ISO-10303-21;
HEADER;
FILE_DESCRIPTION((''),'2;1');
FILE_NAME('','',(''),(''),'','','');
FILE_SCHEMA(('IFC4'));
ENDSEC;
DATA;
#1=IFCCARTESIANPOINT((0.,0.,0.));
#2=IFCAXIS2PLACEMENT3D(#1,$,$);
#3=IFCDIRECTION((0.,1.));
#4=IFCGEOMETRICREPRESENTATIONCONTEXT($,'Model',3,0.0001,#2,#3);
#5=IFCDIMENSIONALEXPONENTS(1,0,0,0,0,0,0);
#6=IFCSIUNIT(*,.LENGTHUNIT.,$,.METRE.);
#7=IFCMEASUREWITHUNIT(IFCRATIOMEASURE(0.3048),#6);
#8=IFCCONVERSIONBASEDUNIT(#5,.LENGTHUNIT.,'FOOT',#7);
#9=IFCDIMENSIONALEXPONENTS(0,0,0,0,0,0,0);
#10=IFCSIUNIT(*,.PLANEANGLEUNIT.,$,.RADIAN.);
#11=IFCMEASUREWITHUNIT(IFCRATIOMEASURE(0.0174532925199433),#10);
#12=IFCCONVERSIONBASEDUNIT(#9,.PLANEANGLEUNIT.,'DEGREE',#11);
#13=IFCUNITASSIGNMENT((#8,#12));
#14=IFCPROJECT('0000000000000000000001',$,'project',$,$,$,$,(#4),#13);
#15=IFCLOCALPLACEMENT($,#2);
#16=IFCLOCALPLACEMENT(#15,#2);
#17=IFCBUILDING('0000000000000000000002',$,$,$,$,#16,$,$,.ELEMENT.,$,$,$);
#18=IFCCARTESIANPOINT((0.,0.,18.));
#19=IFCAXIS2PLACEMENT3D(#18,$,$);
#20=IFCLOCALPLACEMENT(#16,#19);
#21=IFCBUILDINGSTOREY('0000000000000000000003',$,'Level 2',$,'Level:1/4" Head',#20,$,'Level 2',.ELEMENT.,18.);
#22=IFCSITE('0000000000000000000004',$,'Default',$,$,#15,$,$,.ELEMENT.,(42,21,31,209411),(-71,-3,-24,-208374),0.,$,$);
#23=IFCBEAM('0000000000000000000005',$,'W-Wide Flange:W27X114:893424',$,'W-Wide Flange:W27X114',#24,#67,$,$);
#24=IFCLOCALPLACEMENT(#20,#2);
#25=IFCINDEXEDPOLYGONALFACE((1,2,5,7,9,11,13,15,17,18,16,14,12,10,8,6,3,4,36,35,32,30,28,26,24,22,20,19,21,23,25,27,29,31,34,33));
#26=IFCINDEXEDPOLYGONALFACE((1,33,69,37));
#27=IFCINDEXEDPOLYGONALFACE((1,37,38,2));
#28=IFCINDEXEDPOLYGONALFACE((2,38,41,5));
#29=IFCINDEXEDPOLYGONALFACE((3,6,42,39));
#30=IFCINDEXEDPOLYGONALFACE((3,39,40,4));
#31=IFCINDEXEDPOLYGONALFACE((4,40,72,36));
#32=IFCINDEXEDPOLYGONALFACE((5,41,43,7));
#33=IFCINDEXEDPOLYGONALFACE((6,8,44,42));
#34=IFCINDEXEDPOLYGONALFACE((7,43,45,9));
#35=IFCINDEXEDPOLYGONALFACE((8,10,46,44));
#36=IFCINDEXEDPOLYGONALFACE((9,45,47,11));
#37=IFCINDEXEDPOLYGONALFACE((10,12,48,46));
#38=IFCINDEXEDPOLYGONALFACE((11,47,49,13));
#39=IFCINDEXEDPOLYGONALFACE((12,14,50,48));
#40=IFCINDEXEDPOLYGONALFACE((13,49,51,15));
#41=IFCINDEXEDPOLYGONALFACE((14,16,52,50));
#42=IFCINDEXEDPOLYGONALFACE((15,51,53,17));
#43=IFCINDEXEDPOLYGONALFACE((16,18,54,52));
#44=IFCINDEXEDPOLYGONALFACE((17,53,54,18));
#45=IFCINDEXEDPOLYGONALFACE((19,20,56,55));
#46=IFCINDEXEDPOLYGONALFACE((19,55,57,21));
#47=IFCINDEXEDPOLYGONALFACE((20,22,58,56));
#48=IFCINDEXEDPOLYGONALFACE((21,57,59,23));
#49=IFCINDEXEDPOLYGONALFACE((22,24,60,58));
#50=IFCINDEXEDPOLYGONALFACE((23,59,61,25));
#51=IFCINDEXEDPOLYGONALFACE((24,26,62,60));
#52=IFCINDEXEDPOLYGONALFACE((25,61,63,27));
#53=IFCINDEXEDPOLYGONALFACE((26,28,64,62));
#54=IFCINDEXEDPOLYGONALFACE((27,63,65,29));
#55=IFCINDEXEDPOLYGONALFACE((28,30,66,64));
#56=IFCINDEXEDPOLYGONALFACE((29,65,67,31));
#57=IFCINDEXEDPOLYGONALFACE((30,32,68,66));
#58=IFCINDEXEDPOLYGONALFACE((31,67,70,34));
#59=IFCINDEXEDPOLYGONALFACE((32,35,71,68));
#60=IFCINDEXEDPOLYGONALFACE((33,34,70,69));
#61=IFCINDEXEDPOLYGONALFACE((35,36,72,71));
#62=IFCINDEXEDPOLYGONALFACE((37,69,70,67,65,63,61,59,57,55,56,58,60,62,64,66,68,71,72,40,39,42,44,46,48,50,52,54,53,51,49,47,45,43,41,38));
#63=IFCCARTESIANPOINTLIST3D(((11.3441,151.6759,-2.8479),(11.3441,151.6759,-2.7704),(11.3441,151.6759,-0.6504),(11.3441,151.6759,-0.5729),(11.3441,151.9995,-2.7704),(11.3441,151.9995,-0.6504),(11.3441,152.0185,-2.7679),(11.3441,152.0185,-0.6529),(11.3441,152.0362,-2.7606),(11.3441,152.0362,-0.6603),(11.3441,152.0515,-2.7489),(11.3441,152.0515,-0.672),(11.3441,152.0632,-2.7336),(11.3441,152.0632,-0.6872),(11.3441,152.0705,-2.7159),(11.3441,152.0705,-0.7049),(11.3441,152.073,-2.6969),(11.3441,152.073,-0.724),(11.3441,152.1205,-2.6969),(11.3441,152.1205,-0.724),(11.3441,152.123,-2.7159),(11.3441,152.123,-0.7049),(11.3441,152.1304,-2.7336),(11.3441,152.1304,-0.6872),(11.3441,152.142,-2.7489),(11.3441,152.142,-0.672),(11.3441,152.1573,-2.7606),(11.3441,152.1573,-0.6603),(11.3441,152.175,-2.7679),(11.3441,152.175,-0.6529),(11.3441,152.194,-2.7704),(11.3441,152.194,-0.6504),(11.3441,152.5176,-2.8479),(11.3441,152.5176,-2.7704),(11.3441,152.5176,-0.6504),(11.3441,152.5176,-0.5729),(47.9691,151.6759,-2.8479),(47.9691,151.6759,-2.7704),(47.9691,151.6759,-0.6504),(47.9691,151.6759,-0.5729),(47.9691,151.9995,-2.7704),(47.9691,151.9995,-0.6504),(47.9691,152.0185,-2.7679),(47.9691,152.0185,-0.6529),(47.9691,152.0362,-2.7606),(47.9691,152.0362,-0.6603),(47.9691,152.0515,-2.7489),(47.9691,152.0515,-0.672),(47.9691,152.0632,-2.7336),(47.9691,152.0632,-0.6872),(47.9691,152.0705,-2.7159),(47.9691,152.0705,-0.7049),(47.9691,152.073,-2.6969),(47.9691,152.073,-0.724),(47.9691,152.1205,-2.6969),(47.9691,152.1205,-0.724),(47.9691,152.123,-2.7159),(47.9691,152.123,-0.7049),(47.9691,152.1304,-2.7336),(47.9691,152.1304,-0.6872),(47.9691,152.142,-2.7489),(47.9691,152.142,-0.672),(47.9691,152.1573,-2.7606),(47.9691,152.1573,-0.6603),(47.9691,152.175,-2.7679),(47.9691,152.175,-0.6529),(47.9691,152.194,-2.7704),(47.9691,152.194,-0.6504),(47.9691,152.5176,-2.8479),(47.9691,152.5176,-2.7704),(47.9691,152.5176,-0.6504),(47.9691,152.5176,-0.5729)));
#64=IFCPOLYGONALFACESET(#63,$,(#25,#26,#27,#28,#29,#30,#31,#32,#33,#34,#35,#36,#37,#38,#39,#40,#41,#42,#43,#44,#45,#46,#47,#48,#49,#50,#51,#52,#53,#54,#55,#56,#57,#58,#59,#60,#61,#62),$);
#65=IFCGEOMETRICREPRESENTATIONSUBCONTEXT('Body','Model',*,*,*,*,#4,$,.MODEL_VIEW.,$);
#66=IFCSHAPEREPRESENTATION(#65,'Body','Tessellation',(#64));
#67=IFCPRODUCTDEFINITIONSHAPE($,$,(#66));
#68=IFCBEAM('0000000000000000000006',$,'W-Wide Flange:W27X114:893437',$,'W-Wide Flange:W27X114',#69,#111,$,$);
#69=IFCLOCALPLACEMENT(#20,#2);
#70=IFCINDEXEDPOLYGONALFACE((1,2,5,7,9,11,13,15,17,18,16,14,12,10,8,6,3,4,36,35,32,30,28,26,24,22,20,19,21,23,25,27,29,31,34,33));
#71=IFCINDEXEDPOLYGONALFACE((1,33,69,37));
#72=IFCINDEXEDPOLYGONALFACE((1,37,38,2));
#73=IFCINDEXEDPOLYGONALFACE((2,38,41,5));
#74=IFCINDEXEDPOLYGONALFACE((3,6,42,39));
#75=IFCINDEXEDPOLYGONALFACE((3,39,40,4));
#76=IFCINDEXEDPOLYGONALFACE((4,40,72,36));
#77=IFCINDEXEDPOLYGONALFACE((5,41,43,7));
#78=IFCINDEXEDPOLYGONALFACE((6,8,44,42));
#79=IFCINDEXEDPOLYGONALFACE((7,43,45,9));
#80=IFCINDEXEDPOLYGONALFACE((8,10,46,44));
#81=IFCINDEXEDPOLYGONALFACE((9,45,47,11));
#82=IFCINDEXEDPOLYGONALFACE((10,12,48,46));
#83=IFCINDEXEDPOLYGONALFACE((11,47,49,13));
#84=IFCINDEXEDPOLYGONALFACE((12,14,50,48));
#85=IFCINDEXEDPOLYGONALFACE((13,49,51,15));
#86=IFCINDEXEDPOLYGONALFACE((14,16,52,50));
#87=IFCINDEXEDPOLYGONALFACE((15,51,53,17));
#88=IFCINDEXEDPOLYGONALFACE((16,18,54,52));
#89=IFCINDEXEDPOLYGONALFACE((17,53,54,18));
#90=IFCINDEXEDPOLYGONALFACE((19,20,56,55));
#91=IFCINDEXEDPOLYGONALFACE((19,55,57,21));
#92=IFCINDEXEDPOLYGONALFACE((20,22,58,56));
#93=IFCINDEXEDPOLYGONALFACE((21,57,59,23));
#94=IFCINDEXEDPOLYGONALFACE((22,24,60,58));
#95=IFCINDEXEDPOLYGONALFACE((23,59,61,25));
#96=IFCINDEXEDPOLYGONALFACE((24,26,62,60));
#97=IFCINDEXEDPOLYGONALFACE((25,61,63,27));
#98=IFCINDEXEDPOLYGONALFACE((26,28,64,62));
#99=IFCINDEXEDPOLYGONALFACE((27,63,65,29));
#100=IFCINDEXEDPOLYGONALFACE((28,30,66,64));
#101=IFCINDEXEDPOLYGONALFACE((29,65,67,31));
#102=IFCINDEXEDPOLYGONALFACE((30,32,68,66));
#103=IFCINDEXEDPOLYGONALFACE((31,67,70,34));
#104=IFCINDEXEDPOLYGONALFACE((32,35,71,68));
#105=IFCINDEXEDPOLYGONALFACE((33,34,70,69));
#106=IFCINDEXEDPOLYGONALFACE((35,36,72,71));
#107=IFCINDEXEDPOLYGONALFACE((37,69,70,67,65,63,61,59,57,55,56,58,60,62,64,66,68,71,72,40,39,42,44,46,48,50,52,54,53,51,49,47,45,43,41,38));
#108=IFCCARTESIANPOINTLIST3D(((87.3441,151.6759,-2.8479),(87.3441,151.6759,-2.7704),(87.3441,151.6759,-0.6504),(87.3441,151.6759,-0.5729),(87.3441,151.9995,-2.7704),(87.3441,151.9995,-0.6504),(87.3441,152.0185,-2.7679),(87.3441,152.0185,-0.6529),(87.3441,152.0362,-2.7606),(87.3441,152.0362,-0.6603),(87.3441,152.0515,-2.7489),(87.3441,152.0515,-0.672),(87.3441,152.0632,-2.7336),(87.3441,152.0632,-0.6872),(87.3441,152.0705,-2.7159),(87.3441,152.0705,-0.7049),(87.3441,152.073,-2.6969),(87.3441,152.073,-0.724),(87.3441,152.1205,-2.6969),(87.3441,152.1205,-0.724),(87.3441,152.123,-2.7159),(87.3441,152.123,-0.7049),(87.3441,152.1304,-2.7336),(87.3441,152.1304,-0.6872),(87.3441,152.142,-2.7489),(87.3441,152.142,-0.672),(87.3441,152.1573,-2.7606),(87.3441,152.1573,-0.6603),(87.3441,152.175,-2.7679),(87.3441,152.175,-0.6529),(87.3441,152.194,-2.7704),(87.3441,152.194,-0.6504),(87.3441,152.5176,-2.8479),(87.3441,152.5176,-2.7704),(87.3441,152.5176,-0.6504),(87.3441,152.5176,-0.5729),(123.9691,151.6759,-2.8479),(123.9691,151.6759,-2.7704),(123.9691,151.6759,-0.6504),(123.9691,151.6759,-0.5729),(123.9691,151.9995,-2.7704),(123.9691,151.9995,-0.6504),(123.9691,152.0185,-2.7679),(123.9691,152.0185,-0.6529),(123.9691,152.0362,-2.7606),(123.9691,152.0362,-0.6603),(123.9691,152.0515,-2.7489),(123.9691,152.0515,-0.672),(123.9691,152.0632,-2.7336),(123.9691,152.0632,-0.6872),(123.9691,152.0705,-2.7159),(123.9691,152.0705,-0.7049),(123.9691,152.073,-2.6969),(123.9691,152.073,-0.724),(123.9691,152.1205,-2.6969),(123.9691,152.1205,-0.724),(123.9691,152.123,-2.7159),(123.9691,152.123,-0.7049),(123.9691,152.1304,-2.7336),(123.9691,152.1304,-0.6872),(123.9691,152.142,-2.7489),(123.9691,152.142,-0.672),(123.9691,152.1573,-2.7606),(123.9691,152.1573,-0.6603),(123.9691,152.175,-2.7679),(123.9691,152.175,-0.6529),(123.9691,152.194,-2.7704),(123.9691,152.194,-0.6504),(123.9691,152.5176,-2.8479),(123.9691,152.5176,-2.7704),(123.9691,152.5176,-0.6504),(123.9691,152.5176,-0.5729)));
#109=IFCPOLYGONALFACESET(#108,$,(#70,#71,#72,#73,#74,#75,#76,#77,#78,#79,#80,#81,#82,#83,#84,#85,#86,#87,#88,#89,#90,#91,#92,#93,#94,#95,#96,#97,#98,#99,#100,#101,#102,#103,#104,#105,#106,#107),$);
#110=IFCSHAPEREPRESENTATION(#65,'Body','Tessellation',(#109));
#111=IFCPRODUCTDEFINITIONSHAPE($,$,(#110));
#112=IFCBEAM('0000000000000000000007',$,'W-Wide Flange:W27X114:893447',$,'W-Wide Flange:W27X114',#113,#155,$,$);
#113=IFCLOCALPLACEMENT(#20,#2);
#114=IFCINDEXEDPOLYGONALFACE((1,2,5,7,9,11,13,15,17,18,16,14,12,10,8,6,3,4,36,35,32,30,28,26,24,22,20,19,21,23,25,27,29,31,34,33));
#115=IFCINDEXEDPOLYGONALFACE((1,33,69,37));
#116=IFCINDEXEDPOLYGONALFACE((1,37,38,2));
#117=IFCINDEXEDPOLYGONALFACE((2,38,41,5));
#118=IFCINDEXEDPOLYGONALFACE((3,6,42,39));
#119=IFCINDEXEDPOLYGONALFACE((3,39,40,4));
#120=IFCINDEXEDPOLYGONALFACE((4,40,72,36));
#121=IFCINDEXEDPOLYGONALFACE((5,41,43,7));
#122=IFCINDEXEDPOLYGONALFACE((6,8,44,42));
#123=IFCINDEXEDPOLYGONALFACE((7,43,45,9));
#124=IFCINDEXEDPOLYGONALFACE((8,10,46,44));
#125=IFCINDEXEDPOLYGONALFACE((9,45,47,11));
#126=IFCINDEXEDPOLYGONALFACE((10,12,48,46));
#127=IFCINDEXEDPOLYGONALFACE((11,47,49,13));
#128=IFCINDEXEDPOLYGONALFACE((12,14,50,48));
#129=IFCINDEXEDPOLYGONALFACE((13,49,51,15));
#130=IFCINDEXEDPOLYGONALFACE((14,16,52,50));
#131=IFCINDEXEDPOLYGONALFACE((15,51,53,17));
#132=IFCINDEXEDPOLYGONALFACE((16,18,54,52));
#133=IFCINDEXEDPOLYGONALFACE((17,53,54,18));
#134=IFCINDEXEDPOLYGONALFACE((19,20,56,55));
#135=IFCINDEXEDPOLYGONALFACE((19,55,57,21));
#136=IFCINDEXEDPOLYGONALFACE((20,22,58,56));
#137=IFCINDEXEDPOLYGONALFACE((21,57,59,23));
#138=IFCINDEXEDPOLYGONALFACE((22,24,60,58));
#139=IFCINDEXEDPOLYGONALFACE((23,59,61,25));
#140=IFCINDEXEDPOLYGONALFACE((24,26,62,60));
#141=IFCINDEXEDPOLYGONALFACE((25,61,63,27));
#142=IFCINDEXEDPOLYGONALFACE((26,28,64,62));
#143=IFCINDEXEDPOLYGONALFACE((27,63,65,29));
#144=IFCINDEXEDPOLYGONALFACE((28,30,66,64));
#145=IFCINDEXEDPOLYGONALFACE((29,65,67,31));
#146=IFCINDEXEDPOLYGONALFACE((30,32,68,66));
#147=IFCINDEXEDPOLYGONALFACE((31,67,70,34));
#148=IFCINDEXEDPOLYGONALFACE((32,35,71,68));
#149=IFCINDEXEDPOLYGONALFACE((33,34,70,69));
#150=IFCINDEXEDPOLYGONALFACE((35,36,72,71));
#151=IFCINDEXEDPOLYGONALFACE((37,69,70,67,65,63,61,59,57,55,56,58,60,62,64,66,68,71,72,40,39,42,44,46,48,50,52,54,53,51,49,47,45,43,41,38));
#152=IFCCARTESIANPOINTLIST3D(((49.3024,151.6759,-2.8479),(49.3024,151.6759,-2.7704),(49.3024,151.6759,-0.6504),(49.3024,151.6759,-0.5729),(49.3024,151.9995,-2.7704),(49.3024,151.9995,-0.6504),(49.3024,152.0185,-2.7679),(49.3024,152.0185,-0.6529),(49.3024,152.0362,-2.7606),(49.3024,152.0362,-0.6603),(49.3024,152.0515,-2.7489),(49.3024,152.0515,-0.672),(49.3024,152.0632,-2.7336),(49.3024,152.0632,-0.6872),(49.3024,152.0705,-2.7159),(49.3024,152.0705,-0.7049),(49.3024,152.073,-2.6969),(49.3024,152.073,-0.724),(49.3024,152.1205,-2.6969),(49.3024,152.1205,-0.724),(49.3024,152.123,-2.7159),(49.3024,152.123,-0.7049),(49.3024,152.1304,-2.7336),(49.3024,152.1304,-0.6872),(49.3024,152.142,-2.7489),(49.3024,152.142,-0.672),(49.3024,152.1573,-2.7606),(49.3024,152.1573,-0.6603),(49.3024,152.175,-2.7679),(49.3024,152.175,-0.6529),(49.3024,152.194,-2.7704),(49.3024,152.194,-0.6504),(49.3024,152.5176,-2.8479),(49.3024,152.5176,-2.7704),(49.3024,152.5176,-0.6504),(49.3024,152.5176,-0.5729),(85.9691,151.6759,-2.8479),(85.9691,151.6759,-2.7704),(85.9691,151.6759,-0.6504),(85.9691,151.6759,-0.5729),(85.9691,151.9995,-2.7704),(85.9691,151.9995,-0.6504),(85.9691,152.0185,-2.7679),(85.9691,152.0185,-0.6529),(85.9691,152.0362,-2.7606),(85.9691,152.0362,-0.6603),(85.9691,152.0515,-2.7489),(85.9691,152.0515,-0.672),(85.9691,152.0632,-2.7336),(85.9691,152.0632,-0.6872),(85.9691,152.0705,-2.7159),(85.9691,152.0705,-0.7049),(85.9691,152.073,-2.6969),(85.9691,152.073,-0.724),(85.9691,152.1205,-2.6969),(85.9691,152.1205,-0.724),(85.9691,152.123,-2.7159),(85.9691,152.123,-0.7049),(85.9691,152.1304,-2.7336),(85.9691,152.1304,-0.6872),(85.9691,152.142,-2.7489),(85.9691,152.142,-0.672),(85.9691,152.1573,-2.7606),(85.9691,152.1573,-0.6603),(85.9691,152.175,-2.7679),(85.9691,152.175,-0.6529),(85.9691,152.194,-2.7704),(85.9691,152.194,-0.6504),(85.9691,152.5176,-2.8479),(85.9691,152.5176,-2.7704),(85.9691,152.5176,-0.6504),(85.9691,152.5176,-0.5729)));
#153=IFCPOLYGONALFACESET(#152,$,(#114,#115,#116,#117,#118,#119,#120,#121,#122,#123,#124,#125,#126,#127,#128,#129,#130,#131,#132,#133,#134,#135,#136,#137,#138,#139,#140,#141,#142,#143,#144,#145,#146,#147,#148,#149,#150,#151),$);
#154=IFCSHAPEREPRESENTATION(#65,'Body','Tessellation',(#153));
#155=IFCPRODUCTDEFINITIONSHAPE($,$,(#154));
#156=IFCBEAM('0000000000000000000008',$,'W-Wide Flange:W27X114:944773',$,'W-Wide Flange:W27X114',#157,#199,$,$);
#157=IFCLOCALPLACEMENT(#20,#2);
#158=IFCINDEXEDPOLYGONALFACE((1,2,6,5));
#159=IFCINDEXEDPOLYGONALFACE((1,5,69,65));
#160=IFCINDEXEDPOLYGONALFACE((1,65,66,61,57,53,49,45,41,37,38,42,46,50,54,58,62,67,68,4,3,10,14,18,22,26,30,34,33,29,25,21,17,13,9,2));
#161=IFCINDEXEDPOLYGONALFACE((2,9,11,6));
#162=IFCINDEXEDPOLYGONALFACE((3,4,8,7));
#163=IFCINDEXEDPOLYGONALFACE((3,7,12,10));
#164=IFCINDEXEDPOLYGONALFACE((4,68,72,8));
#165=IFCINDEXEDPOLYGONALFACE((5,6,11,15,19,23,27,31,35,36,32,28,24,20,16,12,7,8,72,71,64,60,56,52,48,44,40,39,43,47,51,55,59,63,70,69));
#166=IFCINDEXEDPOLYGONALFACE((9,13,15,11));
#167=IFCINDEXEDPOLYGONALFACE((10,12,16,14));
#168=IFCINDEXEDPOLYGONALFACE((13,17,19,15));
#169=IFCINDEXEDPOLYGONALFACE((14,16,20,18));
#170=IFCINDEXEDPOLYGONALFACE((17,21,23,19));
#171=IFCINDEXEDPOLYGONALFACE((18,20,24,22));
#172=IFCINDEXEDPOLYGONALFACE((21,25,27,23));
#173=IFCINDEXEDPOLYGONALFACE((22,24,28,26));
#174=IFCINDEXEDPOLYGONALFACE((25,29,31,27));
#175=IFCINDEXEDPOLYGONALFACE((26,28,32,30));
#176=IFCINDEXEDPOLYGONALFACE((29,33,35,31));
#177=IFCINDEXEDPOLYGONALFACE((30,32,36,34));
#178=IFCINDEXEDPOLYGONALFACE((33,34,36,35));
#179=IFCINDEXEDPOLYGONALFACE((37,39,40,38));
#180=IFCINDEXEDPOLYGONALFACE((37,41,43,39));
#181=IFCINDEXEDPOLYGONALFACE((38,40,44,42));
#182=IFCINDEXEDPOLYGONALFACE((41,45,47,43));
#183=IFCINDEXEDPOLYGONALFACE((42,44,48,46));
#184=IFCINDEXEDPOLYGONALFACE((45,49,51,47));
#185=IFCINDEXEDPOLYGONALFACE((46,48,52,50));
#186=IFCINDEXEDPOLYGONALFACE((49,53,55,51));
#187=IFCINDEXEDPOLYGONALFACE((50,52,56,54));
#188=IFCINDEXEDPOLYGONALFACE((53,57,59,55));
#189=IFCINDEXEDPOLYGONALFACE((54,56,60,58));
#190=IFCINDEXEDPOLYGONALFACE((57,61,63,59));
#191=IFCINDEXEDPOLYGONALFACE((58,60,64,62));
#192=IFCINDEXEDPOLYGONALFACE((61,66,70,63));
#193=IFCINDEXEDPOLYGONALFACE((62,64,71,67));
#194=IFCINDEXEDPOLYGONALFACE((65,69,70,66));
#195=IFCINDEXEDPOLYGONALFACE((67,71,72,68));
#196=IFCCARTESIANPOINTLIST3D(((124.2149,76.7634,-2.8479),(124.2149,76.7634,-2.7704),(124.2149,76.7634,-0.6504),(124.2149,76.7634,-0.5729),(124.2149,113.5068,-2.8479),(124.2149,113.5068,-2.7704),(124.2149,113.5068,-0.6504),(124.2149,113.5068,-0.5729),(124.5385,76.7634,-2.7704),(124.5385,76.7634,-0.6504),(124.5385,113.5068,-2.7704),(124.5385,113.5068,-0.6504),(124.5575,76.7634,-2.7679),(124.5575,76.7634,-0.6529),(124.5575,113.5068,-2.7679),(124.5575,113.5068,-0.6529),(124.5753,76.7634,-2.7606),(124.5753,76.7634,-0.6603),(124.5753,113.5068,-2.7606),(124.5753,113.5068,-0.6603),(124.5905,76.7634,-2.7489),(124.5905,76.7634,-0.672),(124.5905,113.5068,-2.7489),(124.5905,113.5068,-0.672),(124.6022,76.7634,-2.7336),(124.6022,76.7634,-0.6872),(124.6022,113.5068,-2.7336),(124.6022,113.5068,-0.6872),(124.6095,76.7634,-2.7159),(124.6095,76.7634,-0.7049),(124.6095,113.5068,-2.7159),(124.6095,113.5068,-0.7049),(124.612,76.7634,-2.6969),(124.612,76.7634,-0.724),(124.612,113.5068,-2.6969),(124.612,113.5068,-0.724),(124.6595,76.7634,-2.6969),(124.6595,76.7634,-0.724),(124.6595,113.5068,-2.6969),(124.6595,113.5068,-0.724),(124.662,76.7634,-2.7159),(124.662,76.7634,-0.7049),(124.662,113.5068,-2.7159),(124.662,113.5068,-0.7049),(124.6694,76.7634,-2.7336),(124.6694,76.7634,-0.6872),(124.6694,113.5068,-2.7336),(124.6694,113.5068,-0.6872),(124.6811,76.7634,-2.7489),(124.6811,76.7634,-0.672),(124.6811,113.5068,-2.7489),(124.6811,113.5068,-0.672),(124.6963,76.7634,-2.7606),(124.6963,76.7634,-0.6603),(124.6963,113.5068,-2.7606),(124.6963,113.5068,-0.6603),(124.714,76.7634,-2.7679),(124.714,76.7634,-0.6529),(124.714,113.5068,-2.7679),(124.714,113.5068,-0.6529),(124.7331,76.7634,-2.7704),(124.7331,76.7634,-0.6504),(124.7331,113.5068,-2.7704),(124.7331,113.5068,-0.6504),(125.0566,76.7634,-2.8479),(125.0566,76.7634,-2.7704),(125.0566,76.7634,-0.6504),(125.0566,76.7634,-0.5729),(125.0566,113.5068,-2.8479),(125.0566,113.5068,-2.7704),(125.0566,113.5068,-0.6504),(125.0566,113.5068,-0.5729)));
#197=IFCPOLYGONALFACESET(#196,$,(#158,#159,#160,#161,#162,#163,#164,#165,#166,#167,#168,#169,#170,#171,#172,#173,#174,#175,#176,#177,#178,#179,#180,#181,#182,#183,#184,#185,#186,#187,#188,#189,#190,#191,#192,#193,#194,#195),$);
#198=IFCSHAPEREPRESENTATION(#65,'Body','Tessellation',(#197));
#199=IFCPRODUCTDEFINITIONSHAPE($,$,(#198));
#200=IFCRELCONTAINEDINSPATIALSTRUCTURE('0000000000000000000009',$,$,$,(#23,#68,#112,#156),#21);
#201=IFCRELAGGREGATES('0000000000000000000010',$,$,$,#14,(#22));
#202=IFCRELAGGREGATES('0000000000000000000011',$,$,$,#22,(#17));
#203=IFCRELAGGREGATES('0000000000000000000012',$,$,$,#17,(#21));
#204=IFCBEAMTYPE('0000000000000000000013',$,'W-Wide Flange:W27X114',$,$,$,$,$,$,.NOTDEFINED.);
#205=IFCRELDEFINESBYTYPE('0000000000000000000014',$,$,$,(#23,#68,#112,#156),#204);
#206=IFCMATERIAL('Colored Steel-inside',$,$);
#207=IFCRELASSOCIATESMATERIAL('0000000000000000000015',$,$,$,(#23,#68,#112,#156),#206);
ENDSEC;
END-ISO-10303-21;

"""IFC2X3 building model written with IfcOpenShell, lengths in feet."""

from ifc_helpers import new_model, entity, si_unit, converted_unit, direction, frame, frame_2d, origin, place, context, subcontext, project, spatial, i_section, extrude, material, type_object, element, save


model = new_model("IFC2X3")

# Units and contexts
model_context = context("Model", 3, precision=0.0001, world=origin(), true_north=direction((0.0, 1.0)))
body_context = subcontext(model_context, "Body", "Model", "MODEL_VIEW")
ifc_project = project(units=[converted_unit("LENGTHUNIT", "FOOT", entity("IfcRatioMeasure", 0.3048), si_unit("LENGTHUNIT", "METRE"), dimensions=[1, 0, 0, 0, 0, 0, 0]), converted_unit("PLANEANGLEUNIT", "DEGREE", entity("IfcRatioMeasure", 0.0174532925199433), si_unit("PLANEANGLEUNIT", "RADIAN"), dimensions=[0, 0, 0, 0, 0, 0, 0])], contexts=[model_context])

# Site, building, storey
site_placement = place(None, origin())
site = spatial("IfcSite", under=ifc_project, at=site_placement, Name="Default", CompositionType="ELEMENT", RefLatitude=(42, 21, 31, 209411), RefLongitude=(-71, -3, -24, -208374), RefElevation=0.0)
building_placement = place(site_placement, origin())
building = spatial("IfcBuilding", under=site, at=building_placement, CompositionType="ELEMENT")
storey_placement = place(building_placement, frame((0.0, 0.0, 18.0)))
storey = spatial("IfcBuildingStorey", under=building, at=storey_placement, Name="Level 2", ObjectType="Level:1/4\" Head", LongName="Level 2", CompositionType="ELEMENT", Elevation=18.0)

# Shared definitions
ifc_material_1 = material(Name="Colored Steel-inside")

# Beams
beam_type_1 = type_object("IfcBeamType", Name="W-Wide Flange:W27X114", PredefinedType="NOTDEFINED")
beam_1_placement = place(storey_placement, frame((10.6358, 152.0968, 0.0)))
element("IfcBeam", 1, at=beam_1_placement, inside=storey, type_object=beam_type_1, material=ifc_material_1, Name="W-Wide Flange:W27X114:893424", ObjectType="W-Wide Flange:W27X114", context=body_context, shape_type="SweptSolid", body=[
    extrude(i_section(OverallWidth=0.8417, OverallDepth=2.275, WebThickness=0.0475, FlangeThickness=0.0775, FilletRadius=0.0735, at=frame_2d((0.0, 0.0), x_axis=(0.0, 1.0))), frame((0.7083, 0.0, -1.7104), z_axis=(1.0, 0.0, 0.0), x_axis=(0.0, 0.0, -1.0)), (0.0, 0.0, 1.0), 36.625),
])
beam_2_placement = place(storey_placement, frame((86.6358, 152.0968, 0.0)))
element("IfcBeam", 2, at=beam_2_placement, inside=storey, type_object=beam_type_1, material=ifc_material_1, Name="W-Wide Flange:W27X114:893437", ObjectType="W-Wide Flange:W27X114", context=body_context, shape_type="SweptSolid", body=[
    extrude(i_section(OverallWidth=0.8417, OverallDepth=2.275, WebThickness=0.0475, FlangeThickness=0.0775, FilletRadius=0.0735, at=frame_2d((0.0, 0.0), x_axis=(0.0, 1.0))), frame((0.7083, 0.0, -1.7104), z_axis=(1.0, 0.0, 0.0), x_axis=(0.0, 0.0, -1.0)), (0.0, 0.0, 1.0), 36.625),
])
beam_3_placement = place(storey_placement, frame((48.2795, 152.0968, 0.0)))
element("IfcBeam", 3, at=beam_3_placement, inside=storey, type_object=beam_type_1, material=ifc_material_1, Name="W-Wide Flange:W27X114:893447", ObjectType="W-Wide Flange:W27X114", context=body_context, shape_type="SweptSolid", body=[
    extrude(i_section(OverallWidth=0.8417, OverallDepth=2.275, WebThickness=0.0475, FlangeThickness=0.0775, FilletRadius=0.0735, at=frame_2d((0.0, 0.0), x_axis=(0.0, 1.0))), frame((1.0229, 0.0, -1.7104), z_axis=(1.0, 0.0, 0.0), x_axis=(0.0, 0.0, -1.0)), (0.0, 0.0, 1.0), 36.6667),
])
beam_4_placement = place(storey_placement, frame((124.6358, 114.0968, 0.0), z_axis=(0.0, 0.0, 1.0), x_axis=(0.0, -1.0, 0.0)))
element("IfcBeam", 4, at=beam_4_placement, inside=storey, type_object=beam_type_1, material=ifc_material_1, Name="W-Wide Flange:W27X114:944773", ObjectType="W-Wide Flange:W27X114", context=body_context, shape_type="SweptSolid", body=[
    extrude(i_section(OverallWidth=0.8417, OverallDepth=2.275, WebThickness=0.0475, FlangeThickness=0.0775, FilletRadius=0.0735, at=frame_2d((0.0, 0.0), x_axis=(0.0, 1.0))), frame((0.59, 0.0, -1.7104), z_axis=(1.0, 0.0, 0.0), x_axis=(0.0, 0.0, -1.0)), (0.0, 0.0, 1.0), 36.7433),
])

save(model, "model.ifc")
